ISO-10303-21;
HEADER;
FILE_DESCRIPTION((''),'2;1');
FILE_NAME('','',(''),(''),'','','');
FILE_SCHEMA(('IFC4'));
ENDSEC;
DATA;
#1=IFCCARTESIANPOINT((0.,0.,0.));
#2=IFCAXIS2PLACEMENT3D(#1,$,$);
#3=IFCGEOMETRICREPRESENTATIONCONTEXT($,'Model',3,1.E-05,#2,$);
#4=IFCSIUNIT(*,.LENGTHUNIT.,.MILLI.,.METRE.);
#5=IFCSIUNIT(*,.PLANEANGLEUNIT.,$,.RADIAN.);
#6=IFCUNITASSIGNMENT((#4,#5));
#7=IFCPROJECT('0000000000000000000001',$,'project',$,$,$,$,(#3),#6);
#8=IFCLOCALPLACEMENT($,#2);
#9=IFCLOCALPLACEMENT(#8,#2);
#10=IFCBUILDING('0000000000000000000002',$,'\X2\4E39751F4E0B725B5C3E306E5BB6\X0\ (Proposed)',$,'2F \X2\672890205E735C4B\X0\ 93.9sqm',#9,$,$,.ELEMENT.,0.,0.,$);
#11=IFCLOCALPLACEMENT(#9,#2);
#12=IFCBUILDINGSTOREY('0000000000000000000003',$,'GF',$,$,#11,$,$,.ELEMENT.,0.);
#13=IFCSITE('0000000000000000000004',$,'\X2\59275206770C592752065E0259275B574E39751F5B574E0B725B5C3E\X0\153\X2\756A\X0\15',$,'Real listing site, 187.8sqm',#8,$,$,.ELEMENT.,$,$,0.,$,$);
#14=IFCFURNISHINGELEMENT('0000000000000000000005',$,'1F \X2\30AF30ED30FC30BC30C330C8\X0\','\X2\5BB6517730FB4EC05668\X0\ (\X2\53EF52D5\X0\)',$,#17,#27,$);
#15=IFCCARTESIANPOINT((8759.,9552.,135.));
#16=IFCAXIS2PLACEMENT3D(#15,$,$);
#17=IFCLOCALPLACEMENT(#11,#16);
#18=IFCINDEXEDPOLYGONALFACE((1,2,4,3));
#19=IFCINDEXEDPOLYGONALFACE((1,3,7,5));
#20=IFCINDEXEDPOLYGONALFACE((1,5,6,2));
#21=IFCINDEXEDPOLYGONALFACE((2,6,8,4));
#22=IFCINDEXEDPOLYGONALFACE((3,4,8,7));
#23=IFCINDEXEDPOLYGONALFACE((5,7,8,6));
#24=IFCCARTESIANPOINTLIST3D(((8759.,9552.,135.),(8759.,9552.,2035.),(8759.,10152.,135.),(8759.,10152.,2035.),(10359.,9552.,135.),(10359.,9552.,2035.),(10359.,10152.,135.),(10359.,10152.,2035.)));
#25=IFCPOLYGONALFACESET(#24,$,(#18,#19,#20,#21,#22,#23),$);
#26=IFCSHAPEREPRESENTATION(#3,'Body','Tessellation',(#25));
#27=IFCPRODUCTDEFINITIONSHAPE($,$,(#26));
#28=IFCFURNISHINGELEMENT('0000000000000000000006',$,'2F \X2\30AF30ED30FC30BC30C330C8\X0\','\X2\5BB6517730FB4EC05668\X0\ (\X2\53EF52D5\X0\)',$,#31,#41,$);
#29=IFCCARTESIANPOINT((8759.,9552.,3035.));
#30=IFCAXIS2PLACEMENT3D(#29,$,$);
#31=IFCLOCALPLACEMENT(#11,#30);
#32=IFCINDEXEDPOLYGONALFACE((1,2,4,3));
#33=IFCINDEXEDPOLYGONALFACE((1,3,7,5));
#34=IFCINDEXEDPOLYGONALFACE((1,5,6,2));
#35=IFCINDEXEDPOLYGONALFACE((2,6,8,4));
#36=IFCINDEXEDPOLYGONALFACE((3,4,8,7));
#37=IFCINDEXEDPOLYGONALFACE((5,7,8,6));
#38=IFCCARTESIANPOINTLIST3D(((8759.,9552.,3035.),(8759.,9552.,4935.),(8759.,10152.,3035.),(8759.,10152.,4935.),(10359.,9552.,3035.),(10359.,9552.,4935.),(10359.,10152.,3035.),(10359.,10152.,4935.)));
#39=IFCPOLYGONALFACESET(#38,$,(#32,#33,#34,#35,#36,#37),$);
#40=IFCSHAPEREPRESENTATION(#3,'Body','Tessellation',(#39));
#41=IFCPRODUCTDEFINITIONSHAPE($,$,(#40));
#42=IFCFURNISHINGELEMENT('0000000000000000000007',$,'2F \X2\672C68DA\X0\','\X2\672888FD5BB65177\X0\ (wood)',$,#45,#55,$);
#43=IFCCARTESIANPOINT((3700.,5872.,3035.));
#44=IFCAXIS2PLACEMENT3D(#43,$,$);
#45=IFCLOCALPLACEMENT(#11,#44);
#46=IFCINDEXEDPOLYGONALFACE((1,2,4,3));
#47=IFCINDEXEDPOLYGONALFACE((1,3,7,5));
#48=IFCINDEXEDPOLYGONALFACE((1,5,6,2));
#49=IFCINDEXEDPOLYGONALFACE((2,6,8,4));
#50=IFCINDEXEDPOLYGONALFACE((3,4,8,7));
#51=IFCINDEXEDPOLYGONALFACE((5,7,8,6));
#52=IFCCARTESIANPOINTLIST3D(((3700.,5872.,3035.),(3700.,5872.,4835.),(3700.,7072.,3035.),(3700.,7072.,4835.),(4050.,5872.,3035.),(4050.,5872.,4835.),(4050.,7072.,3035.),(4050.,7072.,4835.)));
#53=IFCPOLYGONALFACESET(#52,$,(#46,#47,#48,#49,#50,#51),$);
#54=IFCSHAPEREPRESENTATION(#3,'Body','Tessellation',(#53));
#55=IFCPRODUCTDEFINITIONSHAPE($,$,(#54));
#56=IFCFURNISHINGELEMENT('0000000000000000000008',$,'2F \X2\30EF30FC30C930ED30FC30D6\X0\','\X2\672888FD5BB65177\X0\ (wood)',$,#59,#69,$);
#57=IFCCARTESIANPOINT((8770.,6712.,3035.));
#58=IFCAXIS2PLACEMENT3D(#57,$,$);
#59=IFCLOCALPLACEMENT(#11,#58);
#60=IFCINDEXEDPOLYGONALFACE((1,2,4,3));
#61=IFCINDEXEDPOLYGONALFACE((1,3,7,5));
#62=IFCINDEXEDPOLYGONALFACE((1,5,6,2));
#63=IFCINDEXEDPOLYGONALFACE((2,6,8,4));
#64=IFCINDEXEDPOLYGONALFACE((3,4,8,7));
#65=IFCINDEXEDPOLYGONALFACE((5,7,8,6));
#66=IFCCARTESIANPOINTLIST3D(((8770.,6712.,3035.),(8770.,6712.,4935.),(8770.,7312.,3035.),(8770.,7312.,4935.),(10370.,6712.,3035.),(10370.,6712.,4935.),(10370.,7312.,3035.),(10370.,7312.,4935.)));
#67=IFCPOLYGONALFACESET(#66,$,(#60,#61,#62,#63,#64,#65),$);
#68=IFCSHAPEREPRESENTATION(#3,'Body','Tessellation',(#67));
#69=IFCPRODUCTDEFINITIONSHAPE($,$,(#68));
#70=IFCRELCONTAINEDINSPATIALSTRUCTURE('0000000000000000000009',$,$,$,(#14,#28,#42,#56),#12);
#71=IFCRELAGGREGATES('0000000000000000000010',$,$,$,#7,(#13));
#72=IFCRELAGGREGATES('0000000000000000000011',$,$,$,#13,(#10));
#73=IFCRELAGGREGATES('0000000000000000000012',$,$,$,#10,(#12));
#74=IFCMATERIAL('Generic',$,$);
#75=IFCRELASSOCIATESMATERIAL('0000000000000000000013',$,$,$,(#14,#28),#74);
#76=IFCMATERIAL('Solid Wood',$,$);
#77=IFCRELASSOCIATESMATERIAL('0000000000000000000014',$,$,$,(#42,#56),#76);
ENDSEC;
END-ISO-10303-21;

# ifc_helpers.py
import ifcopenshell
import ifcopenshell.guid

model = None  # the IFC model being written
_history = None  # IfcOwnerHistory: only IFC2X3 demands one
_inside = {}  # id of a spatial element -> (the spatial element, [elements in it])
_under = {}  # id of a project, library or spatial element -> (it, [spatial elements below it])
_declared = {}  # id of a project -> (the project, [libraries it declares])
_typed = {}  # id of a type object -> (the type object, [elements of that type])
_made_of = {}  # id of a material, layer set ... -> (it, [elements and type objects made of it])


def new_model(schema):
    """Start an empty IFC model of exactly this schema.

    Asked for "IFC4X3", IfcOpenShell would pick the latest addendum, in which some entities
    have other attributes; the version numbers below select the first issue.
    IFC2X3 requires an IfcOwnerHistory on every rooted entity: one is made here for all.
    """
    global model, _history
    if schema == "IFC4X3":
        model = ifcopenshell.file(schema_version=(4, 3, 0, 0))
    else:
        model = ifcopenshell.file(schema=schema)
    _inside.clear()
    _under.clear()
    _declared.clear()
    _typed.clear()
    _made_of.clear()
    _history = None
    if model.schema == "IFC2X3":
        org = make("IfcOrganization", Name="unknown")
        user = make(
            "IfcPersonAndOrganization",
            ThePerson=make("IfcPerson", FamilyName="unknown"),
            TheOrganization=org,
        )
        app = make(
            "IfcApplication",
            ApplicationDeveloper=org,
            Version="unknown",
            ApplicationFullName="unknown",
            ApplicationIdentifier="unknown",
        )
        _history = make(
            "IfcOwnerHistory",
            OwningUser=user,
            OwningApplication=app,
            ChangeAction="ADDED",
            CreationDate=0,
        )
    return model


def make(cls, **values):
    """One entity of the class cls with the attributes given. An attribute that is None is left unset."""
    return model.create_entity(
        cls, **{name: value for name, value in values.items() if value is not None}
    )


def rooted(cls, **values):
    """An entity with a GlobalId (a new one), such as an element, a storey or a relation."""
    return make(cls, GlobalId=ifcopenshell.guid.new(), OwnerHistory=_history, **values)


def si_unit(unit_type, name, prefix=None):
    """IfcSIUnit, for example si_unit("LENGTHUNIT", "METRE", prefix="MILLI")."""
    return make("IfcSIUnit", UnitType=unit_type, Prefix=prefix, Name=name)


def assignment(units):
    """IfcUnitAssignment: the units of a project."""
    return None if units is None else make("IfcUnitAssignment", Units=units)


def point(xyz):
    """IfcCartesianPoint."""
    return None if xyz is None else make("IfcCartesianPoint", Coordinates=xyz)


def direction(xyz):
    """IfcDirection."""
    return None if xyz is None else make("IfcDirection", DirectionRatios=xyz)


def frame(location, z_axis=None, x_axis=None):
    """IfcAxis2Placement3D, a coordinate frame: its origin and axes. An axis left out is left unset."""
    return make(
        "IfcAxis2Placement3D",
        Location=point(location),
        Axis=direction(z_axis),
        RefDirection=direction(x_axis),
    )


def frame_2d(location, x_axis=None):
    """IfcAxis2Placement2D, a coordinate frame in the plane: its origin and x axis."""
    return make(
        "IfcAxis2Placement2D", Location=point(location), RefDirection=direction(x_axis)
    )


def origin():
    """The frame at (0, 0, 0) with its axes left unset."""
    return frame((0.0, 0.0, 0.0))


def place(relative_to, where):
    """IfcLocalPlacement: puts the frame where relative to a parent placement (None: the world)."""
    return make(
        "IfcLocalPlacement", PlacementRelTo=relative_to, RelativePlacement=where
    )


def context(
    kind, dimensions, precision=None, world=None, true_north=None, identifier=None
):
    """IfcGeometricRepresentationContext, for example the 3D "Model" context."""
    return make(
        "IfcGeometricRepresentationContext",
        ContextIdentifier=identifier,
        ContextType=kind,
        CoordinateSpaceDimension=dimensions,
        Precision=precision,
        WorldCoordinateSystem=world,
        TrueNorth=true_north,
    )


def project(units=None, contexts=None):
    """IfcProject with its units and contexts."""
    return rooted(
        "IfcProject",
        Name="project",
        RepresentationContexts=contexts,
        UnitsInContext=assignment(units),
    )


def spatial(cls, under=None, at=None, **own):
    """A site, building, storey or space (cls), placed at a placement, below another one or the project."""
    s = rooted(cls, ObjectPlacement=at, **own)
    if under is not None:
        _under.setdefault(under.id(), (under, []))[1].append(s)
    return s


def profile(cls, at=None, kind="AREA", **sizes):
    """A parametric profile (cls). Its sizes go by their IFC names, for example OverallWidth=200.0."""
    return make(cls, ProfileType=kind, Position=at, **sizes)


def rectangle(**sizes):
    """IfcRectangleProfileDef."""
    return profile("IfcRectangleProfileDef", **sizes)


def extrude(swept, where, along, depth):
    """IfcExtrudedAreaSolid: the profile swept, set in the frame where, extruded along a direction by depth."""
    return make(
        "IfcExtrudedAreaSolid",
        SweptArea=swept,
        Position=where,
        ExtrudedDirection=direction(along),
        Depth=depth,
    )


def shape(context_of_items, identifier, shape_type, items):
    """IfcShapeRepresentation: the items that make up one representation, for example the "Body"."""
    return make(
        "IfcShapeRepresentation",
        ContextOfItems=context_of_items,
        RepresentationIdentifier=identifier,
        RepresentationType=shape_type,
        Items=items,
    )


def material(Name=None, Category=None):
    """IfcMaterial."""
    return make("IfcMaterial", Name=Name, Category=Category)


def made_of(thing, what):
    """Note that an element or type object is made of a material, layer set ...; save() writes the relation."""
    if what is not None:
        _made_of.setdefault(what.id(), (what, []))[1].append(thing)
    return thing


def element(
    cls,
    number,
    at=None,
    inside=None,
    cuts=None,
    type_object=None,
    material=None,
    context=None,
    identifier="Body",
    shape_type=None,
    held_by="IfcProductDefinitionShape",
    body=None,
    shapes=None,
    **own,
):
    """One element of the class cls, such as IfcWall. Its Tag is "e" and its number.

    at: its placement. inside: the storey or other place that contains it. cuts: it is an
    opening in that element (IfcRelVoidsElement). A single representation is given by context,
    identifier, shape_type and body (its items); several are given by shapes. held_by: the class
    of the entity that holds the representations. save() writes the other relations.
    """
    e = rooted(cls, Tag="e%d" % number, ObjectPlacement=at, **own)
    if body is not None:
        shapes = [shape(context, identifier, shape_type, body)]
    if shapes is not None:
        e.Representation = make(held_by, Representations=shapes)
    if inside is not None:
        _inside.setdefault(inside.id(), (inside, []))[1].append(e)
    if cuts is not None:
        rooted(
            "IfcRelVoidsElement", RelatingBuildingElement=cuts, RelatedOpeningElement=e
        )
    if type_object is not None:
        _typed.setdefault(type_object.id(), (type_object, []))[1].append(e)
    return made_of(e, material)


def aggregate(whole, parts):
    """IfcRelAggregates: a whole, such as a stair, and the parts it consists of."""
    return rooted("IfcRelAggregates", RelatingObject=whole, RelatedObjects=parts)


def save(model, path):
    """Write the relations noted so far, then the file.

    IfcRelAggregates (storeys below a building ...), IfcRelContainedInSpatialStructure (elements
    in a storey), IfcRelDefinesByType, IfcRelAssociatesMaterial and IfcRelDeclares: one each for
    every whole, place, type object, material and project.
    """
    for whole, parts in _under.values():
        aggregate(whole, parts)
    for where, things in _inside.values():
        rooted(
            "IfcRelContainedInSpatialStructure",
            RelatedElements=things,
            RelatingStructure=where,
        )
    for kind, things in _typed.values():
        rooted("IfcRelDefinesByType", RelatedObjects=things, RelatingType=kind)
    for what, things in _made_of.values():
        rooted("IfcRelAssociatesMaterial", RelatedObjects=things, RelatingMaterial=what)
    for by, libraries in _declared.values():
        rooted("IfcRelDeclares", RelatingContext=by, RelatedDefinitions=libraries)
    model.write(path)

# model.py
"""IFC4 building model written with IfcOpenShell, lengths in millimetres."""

from ifc_helpers import new_model, si_unit, frame, frame_2d, origin, place, context, project, spatial, rectangle, extrude, material, element, save


model = new_model("IFC4")

# Units and contexts
model_context = context("Model", 3, precision=1e-05, world=origin())
ifc_project = project(units=[si_unit("LENGTHUNIT", "METRE", prefix="MILLI"), si_unit("PLANEANGLEUNIT", "RADIAN")], contexts=[model_context])

# Site, building, storey
site_placement = place(None, origin())
site = spatial("IfcSite", under=ifc_project, at=site_placement, Name="大分県大分市大字丹生字下牛尾153番15", ObjectType="Real listing site, 187.8sqm", CompositionType="ELEMENT", RefElevation=0.0)
building_placement = place(site_placement, origin())
building = spatial("IfcBuilding", under=site, at=building_placement, Name="丹生下牛尾の家 (Proposed)", ObjectType="2F 木造平屋 93.9sqm", CompositionType="ELEMENT", ElevationOfRefHeight=0.0, ElevationOfTerrain=0.0)
storey_placement = place(building_placement, origin())
storey = spatial("IfcBuildingStorey", under=building, at=storey_placement, Name="GF", CompositionType="ELEMENT", Elevation=0.0)

# Shared definitions
ifc_material_1 = material(Name="Solid Wood")

# Shared definitions
ifc_material_2 = material(Name="Generic")

# Furnishing elements
furnishing_1_placement = place(storey_placement, frame((8759.0, 9552.0, 135.0)))
element("IfcFurnishingElement", 1, at=furnishing_1_placement, inside=storey, material=ifc_material_2, Name="1F クローゼット", Description="家具・什器 (可動)", context=model_context, shape_type="SweptSolid", body=[
    extrude(rectangle(XDim=1600.0, YDim=600.0, at=frame_2d((800.0, 300.0))), frame((8759.0, 9552.0, 135.0)), (0.0, 0.0, 1.0), 1900.0),
])
furnishing_2_placement = place(storey_placement, frame((8759.0, 9552.0, 3035.0)))
element("IfcFurnishingElement", 2, at=furnishing_2_placement, inside=storey, material=ifc_material_2, Name="2F クローゼット", Description="家具・什器 (可動)", context=model_context, shape_type="SweptSolid", body=[
    extrude(rectangle(XDim=1600.0, YDim=600.0, at=frame_2d((800.0, 300.0))), frame((8759.0, 9552.0, 3035.0)), (0.0, 0.0, 1.0), 1900.0),
])
furnishing_3_placement = place(storey_placement, frame((3700.0, 5872.0, 3035.0)))
element("IfcFurnishingElement", 3, at=furnishing_3_placement, inside=storey, material=ifc_material_1, Name="2F 本棚", Description="木製家具 (wood)", context=model_context, shape_type="SweptSolid", body=[
    extrude(rectangle(XDim=350.0, YDim=1200.0, at=frame_2d((175.0, 600.0))), frame((3700.0, 5872.0, 3035.0)), (0.0, 0.0, 1.0), 1800.0),
])
furnishing_4_placement = place(storey_placement, frame((8770.0, 6712.0, 3035.0)))
element("IfcFurnishingElement", 4, at=furnishing_4_placement, inside=storey, material=ifc_material_1, Name="2F ワードローブ", Description="木製家具 (wood)", context=model_context, shape_type="SweptSolid", body=[
    extrude(rectangle(XDim=1600.0, YDim=600.0, at=frame_2d((800.0, 300.0))), frame((8770.0, 6712.0, 3035.0)), (0.0, 0.0, 1.0), 1900.0),
])

save(model, "model.ifc")
